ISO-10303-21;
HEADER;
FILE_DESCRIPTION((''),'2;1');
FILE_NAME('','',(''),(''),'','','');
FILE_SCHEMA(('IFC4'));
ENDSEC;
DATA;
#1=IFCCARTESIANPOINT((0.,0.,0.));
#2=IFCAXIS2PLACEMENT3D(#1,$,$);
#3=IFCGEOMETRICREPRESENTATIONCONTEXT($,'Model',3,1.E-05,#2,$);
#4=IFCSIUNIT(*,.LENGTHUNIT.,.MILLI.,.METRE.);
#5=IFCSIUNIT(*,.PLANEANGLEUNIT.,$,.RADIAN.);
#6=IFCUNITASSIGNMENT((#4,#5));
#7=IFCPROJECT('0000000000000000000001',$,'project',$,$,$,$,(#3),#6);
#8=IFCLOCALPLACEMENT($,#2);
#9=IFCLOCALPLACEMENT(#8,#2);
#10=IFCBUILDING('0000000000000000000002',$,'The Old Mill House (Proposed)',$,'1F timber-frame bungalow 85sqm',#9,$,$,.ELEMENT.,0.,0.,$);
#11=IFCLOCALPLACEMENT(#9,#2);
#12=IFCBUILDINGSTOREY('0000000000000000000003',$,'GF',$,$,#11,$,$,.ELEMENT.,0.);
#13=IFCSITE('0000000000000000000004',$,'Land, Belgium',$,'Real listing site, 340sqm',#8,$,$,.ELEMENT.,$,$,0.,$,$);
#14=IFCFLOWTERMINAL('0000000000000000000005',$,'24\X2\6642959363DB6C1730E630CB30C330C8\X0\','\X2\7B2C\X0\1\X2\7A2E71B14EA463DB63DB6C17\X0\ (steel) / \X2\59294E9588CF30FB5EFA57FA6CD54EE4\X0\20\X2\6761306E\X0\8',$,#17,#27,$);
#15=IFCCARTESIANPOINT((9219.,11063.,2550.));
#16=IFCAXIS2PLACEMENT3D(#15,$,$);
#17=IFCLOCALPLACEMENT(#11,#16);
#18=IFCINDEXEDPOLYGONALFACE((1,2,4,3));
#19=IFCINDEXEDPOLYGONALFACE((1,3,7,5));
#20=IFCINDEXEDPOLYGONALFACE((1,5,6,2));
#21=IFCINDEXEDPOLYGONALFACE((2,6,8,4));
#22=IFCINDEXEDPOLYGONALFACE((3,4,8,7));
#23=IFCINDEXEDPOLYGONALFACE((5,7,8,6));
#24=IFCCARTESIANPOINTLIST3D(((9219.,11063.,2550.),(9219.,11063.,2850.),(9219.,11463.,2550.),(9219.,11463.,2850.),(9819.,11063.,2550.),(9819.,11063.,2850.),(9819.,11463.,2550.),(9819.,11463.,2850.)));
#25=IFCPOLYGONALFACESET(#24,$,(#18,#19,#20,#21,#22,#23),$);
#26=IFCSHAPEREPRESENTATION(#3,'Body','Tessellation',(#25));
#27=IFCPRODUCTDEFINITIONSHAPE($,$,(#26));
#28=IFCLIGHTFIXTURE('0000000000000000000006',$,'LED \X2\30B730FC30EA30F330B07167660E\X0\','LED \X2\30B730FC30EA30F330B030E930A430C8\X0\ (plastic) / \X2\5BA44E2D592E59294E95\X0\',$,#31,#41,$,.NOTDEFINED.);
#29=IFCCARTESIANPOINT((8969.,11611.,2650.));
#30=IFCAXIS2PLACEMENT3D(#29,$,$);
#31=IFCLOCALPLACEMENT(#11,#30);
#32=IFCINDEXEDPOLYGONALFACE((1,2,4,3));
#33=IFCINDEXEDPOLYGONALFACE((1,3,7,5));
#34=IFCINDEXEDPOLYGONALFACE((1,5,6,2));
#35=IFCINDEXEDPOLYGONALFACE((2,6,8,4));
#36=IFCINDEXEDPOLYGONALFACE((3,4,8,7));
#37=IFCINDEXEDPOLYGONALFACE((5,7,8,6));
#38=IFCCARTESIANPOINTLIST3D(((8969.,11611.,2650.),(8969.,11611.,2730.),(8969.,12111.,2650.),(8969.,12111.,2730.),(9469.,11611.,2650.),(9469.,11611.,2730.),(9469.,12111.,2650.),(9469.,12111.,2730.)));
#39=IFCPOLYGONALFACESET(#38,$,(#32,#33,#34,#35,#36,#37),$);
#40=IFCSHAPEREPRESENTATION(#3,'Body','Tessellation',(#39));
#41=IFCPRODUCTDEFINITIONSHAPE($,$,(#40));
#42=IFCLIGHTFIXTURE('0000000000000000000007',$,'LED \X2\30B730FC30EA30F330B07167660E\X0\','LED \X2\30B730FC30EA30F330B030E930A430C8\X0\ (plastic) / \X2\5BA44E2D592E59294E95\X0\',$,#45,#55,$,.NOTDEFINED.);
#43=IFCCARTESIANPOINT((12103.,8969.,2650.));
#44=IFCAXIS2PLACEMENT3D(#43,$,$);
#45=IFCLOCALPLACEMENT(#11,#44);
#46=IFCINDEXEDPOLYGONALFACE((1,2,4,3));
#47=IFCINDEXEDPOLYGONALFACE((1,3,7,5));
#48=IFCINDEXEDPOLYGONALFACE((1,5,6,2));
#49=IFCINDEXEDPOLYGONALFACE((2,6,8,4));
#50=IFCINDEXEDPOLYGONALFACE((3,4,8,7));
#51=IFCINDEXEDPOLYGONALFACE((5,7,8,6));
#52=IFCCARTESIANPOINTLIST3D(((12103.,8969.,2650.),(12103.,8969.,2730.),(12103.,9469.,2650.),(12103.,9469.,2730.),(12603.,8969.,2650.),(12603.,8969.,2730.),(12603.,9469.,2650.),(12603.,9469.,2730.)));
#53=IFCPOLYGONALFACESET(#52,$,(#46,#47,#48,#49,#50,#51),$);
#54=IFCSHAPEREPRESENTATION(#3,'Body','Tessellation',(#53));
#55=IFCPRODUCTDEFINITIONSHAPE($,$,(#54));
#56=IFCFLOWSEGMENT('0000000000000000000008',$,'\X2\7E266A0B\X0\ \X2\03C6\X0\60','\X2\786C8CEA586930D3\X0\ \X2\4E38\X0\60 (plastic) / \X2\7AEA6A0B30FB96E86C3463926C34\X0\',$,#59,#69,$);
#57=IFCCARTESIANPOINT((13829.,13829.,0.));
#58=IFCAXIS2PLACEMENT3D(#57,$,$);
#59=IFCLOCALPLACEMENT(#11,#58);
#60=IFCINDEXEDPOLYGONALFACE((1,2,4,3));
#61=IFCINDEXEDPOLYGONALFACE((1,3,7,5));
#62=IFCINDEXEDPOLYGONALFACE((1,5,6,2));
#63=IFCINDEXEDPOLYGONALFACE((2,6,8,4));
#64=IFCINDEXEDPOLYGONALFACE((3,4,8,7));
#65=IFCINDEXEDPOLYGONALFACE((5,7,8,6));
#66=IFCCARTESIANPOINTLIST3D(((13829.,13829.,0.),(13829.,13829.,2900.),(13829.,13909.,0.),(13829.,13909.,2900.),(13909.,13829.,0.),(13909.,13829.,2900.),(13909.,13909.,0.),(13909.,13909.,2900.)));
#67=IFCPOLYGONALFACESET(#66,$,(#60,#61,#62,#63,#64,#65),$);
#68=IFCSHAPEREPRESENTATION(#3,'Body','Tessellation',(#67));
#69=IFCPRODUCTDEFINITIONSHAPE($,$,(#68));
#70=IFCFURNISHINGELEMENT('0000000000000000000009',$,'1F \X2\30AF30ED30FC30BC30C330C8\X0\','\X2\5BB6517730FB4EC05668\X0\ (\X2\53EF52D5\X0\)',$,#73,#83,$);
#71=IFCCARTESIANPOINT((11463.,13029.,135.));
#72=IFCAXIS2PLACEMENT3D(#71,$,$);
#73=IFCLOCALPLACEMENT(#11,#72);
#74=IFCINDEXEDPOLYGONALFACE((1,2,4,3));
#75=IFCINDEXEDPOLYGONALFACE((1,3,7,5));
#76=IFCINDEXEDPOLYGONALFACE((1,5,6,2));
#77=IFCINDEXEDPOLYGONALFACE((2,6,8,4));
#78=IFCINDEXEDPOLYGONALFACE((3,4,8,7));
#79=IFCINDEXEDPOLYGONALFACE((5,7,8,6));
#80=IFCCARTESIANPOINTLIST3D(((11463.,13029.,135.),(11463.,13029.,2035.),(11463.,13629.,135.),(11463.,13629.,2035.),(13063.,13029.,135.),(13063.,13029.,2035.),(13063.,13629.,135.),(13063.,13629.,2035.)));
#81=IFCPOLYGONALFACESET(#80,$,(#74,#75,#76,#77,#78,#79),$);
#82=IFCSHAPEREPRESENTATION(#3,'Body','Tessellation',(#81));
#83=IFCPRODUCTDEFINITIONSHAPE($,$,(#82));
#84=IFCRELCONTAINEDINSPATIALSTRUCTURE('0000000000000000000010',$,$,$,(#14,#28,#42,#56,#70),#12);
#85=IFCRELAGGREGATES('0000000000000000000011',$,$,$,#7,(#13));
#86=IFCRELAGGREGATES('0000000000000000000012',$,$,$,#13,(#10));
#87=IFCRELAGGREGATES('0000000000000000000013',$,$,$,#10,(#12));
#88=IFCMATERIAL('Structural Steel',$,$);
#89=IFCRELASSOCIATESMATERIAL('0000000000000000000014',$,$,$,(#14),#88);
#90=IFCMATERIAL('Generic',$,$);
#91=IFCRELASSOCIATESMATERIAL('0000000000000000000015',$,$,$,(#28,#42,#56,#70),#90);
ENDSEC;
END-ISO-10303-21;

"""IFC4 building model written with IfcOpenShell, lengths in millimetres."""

from ifc_helpers import new_model, si_unit, frame, frame_2d, origin, place, context, project, spatial, rectangle, extrude, material, element, save


model = new_model("IFC4")

# Units and contexts
model_context = context("Model", 3, precision=1e-05, world=origin())
ifc_project = project(units=[si_unit("LENGTHUNIT", "METRE", prefix="MILLI"), si_unit("PLANEANGLEUNIT", "RADIAN")], contexts=[model_context])

# Site, building, storey
site_placement = place(None, origin())
site = spatial("IfcSite", under=ifc_project, at=site_placement, Name="Land, Belgium", ObjectType="Real listing site, 340sqm", CompositionType="ELEMENT", RefElevation=0.0)
building_placement = place(site_placement, origin())
building = spatial("IfcBuilding", under=site, at=building_placement, Name="The Old Mill House (Proposed)", ObjectType="1F timber-frame bungalow 85sqm", CompositionType="ELEMENT", ElevationOfRefHeight=0.0, ElevationOfTerrain=0.0)
storey_placement = place(building_placement, origin())
storey = spatial("IfcBuildingStorey", under=building, at=storey_placement, Name="GF", CompositionType="ELEMENT", Elevation=0.0)

# Shared definitions
ifc_material_1 = material(Name="Generic")

# Flow terminal
ifc_material_2 = material(Name="Structural Steel")
flow_terminal_placement = place(storey_placement, frame((9219.0, 11063.0, 2550.0)))
element("IfcFlowTerminal", 1, at=flow_terminal_placement, inside=storey, material=ifc_material_2, Name="24時間換気ユニット", Description="第1種熱交換換気 (steel) / 天井裏・建基法令20条の8", context=model_context, shape_type="SweptSolid", body=[
    extrude(rectangle(XDim=600.0, YDim=400.0, at=frame_2d((300.0, 200.0))), frame((9219.0, 11063.0, 2550.0)), (0.0, 0.0, 1.0), 300.0),
])

# Light fixtures
light_fixture_1_placement = place(storey_placement, frame((8969.0, 11611.0, 2650.0)))
element("IfcLightFixture", 2, at=light_fixture_1_placement, inside=storey, material=ifc_material_1, Name="LED シーリング照明", Description="LED シーリングライト (plastic) / 室中央天井", PredefinedType="NOTDEFINED", context=model_context, shape_type="SweptSolid", body=[
    extrude(rectangle(XDim=500.0, YDim=500.0, at=frame_2d((250.0, 250.0))), frame((8969.0, 11611.0, 2650.0)), (0.0, 0.0, 1.0), 80.0),
])
light_fixture_2_placement = place(storey_placement, frame((12103.0, 8969.0, 2650.0)))
element("IfcLightFixture", 3, at=light_fixture_2_placement, inside=storey, material=ifc_material_1, Name="LED シーリング照明", Description="LED シーリングライト (plastic) / 室中央天井", PredefinedType="NOTDEFINED", context=model_context, shape_type="SweptSolid", body=[
    extrude(rectangle(XDim=500.0, YDim=500.0, at=frame_2d((250.0, 250.0))), frame((12103.0, 8969.0, 2650.0)), (0.0, 0.0, 1.0), 80.0),
])

# Flow segment
flow_segment_placement = place(storey_placement, frame((13829.0, 13829.0, 0.0)))
element("IfcFlowSegment", 4, at=flow_segment_placement, inside=storey, material=ifc_material_1, Name="縦樋 φ60", Description="硬質塩ビ 丸60 (plastic) / 竪樋・雨水排水", context=model_context, shape_type="SweptSolid", body=[
    extrude(rectangle(XDim=80.0, YDim=80.0, at=frame_2d((40.0, 40.0))), frame((13829.0, 13829.0, 0.0)), (0.0, 0.0, 1.0), 2900.0),
])

# Furnishing element
furnishing_placement = place(storey_placement, frame((11463.0, 13029.0, 135.0)))
element("IfcFurnishingElement", 5, at=furnishing_placement, inside=storey, material=ifc_material_1, Name="1F クローゼット", Description="家具・什器 (可動)", context=model_context, shape_type="SweptSolid", body=[
    extrude(rectangle(XDim=1600.0, YDim=600.0, at=frame_2d((800.0, 300.0))), frame((11463.0, 13029.0, 135.0)), (0.0, 0.0, 1.0), 1900.0),
])

save(model, "model.ifc")
